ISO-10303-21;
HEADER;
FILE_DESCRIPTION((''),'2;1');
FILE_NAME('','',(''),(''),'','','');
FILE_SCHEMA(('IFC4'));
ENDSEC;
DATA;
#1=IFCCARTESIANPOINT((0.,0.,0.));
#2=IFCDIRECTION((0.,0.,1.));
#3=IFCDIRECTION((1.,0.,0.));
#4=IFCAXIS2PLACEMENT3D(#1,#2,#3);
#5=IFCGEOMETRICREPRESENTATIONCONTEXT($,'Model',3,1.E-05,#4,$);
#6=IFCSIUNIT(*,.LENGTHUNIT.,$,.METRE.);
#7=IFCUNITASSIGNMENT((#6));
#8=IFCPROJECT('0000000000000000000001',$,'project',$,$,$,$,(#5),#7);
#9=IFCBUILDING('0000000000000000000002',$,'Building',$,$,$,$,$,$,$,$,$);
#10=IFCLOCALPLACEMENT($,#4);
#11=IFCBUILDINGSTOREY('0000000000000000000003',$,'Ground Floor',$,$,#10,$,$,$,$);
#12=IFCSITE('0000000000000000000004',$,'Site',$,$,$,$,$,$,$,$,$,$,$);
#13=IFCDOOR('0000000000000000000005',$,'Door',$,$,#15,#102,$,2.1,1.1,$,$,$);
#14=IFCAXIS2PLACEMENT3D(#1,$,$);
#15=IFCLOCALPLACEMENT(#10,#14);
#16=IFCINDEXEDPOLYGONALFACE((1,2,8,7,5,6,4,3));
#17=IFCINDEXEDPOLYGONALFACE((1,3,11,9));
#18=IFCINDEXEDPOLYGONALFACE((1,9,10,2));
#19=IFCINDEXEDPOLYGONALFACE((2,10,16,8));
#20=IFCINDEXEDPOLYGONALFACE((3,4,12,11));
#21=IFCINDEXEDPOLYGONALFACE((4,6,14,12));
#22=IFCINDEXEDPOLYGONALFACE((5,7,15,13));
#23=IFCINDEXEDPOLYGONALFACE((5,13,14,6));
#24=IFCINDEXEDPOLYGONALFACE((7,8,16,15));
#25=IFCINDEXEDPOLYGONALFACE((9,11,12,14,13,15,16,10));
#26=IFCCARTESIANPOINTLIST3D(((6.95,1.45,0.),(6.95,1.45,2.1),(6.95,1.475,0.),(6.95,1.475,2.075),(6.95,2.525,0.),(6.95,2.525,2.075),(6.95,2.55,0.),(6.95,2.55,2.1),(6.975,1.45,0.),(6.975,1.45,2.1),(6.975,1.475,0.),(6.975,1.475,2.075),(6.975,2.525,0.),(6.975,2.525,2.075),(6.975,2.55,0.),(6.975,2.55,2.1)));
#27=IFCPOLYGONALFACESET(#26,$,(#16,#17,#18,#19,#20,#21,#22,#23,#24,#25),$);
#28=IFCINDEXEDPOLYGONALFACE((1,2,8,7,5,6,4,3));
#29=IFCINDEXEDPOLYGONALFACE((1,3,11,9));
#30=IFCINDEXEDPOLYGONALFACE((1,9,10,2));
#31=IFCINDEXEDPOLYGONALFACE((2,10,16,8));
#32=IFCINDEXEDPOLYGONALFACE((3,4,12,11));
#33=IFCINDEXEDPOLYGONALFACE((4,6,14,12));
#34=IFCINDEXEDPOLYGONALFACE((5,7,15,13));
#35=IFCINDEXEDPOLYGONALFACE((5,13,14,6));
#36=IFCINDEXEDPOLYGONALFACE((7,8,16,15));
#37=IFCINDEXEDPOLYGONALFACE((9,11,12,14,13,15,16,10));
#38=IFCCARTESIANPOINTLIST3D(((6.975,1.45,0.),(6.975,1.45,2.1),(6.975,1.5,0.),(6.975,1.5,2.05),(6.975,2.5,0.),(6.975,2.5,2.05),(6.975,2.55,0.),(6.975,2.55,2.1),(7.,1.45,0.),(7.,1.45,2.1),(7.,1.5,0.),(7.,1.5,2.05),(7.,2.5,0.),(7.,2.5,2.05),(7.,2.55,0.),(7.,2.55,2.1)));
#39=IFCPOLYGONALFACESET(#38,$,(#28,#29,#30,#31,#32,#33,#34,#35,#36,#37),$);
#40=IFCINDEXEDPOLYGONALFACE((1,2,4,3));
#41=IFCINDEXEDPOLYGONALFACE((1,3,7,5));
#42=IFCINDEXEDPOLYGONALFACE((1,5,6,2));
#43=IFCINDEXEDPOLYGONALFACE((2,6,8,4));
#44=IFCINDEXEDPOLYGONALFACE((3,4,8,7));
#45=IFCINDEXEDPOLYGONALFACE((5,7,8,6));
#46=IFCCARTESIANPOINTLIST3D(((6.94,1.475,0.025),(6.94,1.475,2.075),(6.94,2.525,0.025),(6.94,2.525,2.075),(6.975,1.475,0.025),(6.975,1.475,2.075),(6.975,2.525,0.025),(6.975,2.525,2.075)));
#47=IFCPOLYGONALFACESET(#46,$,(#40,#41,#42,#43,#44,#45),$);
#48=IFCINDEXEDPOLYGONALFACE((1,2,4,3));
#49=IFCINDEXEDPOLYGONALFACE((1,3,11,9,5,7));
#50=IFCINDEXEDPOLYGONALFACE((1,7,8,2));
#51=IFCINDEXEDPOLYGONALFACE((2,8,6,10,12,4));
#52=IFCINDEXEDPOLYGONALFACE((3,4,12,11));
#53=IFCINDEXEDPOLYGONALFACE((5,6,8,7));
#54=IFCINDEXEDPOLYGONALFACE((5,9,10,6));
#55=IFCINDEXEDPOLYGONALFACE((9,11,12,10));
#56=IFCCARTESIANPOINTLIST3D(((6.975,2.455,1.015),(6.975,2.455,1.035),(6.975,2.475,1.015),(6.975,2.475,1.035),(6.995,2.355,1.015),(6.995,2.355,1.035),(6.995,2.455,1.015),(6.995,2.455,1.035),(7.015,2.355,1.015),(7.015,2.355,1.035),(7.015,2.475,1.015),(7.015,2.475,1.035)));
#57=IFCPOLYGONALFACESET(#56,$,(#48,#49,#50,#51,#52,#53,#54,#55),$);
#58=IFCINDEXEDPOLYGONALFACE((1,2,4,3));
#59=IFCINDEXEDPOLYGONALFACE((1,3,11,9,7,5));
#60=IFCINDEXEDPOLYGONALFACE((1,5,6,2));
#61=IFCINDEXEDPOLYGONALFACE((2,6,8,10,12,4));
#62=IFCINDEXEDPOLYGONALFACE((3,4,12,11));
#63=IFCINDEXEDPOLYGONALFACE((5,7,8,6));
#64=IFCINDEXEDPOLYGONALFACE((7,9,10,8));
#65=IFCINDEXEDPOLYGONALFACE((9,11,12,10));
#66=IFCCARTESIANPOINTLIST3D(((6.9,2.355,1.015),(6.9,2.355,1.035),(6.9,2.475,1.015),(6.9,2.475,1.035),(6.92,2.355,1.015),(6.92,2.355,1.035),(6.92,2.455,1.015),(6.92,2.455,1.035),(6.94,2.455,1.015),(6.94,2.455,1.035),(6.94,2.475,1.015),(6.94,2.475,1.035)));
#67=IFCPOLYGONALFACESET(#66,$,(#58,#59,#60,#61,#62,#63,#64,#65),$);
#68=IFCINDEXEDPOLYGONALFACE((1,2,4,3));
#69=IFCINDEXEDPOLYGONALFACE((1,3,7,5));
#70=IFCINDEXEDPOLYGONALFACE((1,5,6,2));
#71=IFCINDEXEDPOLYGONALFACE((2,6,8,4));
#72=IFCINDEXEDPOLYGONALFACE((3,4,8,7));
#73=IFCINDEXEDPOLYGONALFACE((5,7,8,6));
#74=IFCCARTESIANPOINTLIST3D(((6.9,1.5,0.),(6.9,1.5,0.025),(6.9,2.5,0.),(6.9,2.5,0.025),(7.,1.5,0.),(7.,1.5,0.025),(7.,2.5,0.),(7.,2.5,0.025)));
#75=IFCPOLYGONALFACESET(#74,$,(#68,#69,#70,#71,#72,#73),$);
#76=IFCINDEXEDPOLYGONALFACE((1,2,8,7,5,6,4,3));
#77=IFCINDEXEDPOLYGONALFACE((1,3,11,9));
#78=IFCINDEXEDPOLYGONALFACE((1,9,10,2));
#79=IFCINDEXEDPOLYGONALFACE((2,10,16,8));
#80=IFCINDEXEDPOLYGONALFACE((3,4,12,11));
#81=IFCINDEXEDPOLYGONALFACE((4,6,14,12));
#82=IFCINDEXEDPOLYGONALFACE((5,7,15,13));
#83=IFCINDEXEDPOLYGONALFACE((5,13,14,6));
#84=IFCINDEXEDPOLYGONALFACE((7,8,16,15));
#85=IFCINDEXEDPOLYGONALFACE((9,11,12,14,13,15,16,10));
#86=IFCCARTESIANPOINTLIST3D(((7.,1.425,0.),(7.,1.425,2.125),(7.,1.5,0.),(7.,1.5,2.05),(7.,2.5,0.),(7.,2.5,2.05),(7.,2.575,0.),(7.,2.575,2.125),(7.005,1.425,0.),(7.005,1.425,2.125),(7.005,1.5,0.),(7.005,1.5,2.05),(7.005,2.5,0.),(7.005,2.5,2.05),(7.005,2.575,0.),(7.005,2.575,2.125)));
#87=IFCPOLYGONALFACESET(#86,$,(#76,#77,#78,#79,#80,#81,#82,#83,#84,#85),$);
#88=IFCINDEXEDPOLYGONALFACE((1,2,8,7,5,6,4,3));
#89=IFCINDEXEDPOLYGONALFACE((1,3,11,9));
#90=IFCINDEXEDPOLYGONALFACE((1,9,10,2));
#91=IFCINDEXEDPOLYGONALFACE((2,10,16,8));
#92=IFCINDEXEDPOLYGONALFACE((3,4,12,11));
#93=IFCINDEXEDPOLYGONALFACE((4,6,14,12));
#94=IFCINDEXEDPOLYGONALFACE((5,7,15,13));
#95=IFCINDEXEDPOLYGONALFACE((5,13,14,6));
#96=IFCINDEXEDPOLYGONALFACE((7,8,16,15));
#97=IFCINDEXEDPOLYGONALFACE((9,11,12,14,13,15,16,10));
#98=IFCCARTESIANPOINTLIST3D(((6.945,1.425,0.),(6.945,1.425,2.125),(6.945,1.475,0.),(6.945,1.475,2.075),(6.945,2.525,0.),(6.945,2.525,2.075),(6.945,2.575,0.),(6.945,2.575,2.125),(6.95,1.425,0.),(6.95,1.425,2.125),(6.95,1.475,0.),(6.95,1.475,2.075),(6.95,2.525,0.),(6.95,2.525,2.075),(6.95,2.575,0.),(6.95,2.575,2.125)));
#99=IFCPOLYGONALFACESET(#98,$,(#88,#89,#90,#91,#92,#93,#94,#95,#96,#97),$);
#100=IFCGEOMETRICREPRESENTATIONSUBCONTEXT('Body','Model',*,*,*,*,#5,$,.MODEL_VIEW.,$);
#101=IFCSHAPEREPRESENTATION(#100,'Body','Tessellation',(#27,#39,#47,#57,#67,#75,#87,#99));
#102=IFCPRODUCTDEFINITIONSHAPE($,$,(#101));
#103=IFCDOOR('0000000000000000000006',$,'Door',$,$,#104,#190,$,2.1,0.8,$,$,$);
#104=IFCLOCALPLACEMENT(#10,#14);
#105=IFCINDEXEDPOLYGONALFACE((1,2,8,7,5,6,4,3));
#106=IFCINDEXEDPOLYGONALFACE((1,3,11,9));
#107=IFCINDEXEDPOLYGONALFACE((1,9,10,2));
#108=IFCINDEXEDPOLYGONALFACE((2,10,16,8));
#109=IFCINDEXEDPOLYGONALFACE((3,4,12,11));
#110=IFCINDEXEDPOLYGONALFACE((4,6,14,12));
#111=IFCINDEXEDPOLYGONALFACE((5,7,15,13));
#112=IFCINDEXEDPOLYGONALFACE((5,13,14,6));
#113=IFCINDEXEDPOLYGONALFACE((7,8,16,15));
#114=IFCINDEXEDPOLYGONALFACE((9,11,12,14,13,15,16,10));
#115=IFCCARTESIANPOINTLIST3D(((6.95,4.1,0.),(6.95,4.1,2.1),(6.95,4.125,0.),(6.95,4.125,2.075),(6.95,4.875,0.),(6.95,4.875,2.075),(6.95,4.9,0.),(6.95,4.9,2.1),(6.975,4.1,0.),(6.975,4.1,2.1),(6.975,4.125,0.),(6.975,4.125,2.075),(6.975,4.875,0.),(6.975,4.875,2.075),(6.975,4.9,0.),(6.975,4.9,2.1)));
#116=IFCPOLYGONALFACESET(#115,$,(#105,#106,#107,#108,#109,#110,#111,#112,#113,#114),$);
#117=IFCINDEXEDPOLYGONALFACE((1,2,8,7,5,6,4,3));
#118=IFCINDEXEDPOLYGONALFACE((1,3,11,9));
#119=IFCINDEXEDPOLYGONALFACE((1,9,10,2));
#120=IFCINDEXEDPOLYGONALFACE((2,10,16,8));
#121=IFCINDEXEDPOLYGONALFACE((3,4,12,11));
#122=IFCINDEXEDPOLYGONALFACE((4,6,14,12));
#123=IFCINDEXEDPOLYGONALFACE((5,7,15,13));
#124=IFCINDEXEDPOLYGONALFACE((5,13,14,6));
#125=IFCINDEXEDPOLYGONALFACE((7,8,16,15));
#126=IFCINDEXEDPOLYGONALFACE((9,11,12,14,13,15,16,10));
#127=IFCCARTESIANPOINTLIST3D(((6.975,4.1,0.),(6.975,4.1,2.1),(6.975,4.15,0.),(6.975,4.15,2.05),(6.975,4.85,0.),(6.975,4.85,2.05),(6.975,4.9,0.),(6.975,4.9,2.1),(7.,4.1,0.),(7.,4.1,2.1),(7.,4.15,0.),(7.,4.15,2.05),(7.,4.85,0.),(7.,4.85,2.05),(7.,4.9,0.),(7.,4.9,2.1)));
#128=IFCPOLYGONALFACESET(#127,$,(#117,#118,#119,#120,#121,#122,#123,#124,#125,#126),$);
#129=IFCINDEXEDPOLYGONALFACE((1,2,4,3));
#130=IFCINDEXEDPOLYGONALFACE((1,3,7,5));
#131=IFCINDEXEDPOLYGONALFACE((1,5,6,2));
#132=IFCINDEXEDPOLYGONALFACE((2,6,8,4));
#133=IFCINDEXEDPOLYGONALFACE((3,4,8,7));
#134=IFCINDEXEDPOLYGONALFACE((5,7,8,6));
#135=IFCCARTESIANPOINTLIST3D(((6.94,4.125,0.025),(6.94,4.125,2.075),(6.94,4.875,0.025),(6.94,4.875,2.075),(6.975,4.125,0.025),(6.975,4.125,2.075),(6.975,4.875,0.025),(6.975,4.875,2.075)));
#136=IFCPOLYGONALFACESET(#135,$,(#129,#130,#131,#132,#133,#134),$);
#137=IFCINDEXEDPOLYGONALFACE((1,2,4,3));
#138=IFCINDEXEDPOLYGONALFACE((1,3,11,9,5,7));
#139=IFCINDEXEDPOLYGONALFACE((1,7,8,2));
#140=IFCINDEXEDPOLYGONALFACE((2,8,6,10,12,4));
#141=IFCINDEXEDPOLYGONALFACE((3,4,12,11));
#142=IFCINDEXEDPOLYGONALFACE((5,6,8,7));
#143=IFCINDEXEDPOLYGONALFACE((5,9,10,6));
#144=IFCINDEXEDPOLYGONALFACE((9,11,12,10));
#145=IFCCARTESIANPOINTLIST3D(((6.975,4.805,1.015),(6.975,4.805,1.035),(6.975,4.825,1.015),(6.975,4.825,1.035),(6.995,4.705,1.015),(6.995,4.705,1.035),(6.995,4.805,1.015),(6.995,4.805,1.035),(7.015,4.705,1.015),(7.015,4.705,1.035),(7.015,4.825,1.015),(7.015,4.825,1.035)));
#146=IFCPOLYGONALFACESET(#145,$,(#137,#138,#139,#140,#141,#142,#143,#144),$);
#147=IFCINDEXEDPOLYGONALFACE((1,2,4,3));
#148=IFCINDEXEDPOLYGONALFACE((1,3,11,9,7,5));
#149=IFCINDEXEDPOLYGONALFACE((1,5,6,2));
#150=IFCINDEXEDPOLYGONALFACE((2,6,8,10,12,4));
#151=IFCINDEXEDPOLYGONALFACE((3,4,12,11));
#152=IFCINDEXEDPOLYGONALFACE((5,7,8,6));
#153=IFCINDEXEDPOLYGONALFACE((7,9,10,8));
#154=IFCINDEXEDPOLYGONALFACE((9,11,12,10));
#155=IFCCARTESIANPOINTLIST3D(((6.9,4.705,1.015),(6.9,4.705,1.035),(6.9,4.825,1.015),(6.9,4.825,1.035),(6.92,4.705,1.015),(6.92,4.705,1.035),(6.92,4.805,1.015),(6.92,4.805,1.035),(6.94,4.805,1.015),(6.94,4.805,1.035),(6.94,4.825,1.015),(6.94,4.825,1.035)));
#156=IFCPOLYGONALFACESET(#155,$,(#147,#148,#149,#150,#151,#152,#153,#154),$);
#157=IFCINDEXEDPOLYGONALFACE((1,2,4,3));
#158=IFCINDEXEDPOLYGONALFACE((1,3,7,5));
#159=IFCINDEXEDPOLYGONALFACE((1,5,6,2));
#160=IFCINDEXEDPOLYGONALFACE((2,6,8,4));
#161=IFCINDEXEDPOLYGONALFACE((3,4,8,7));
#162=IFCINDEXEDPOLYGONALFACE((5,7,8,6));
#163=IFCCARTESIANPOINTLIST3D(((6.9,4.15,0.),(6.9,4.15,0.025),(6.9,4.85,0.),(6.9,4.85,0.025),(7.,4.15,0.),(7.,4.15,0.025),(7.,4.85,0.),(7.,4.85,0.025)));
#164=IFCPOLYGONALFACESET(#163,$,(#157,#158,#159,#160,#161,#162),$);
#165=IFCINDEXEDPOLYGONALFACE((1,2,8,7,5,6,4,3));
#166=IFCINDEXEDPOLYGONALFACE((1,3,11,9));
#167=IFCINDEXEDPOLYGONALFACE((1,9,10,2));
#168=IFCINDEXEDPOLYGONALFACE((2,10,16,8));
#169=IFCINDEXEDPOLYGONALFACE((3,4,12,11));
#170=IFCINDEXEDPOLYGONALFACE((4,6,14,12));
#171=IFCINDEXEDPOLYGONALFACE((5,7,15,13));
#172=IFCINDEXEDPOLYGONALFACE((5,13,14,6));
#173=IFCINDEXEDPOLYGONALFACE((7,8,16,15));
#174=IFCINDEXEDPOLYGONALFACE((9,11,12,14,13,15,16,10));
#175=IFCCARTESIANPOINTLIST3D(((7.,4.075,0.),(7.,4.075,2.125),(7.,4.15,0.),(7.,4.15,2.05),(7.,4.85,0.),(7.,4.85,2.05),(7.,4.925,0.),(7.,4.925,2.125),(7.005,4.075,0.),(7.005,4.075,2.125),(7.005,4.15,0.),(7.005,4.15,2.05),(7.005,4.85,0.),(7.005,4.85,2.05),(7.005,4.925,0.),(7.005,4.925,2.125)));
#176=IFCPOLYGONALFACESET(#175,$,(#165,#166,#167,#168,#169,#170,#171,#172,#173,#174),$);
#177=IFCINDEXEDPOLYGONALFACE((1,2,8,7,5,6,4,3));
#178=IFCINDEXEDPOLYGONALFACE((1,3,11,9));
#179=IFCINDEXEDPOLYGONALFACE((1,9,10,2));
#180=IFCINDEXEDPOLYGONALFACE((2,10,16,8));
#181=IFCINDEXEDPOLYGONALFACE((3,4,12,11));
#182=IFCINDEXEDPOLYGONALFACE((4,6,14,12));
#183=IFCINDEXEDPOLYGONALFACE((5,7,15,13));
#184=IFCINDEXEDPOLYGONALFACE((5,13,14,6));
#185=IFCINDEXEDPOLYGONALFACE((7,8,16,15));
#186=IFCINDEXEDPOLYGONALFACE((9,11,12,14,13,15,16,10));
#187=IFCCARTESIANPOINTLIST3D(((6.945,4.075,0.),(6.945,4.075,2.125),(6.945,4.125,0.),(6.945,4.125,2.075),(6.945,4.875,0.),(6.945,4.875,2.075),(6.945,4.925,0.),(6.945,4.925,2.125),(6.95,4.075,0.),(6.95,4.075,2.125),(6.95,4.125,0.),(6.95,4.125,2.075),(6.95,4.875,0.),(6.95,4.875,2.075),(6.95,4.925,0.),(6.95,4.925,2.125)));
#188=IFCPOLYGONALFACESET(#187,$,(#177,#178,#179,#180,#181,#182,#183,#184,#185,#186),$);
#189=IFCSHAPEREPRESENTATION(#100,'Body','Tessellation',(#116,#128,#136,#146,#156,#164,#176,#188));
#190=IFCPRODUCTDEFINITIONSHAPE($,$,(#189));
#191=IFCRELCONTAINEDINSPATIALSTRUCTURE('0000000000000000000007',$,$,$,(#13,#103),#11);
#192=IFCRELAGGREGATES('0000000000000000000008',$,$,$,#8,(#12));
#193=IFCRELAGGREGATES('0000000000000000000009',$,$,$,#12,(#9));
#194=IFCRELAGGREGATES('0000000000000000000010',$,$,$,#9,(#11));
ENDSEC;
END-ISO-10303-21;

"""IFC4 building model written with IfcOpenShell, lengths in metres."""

from ifc_helpers import new_model, si_unit, frame, origin_with_axes, place, context, subcontext, project, spatial, line, indexed_curve, outline, extrude, element, save


model = new_model("IFC4")

# Units and contexts
model_context = context("Model", 3, precision=1e-05, world=origin_with_axes())
body_context = subcontext(model_context, "Body", "Model", "MODEL_VIEW")
ifc_project = project(units=[si_unit("LENGTHUNIT", "METRE")], contexts=[model_context])

# Site, building, storey
site = spatial("IfcSite", under=ifc_project, Name="Site")
building = spatial("IfcBuilding", under=site, Name="Building")
storey_placement = place(None, origin_with_axes())
storey = spatial("IfcBuildingStorey", under=building, at=storey_placement, Name="Ground Floor")

# Doors
door_1_placement = place(storey_placement, frame((7.0, 1.45, 0.0), z_axis=(0.0, 0.0, 1.0), x_axis=(0.0, 1.0, 0.0)))
element("IfcDoor", 1, at=door_1_placement, inside=storey, Name="Door", OverallHeight=2.1, OverallWidth=1.1, context=body_context, shape_type="SweptSolid", body=[
    extrude(outline(indexed_curve([(0.0, 0.0), (0.0, 2.1), (1.1, 2.1), (1.1, 0.0), (1.075, 0.0), (1.075, 2.075), (0.025, 2.075), (0.025, 0.0)], segments=[line(1, 2, 3, 4, 5, 6, 7, 8, 1)])), frame((0.0, 0.025, 0.0), z_axis=(0.0, -1.0, 0.0), x_axis=(1.0, 0.0, 0.0)), (0.0, 0.0, -1.0), 0.025),
    extrude(outline(indexed_curve([(0.0, 0.0), (0.0, 2.1), (1.1, 2.1), (1.1, 0.0), (1.05, 0.0), (1.05, 2.05), (0.05, 2.05), (0.05, 0.0)], segments=[line(1, 2, 3, 4, 5, 6, 7, 8, 1)])), frame((0.0, 0.0, 0.0), z_axis=(0.0, -1.0, 0.0), x_axis=(1.0, 0.0, 0.0)), (0.0, 0.0, -1.0), 0.025),
    extrude(outline(indexed_curve([(0.0, 0.0), (1.05, 0.0), (1.05, 0.035), (0.0, 0.035)], segments=[line(1, 2, 3, 4, 1)])), frame((0.025, 0.025, 0.025), z_axis=(0.0, 0.0, 1.0), x_axis=(1.0, 0.0, 0.0)), (0.0, 0.0, 1.0), 2.05),
    extrude(outline(indexed_curve([(0.0, 0.0), (0.0, -0.04), (-0.12, -0.04), (-0.12, -0.02), (-0.02, -0.02), (-0.02, 0.0)], segments=[line(1, 2, 3, 4, 5, 6, 1)])), frame((1.025, 0.025, 1.015), z_axis=(0.0, 0.0, 1.0), x_axis=(1.0, 0.0, 0.0)), (0.0, 0.0, 1.0), 0.02),
    extrude(outline(indexed_curve([(0.0, 0.0), (0.0, 0.04), (-0.12, 0.04), (-0.12, 0.02), (-0.02, 0.02), (-0.02, 0.0)], segments=[line(1, 2, 3, 4, 5, 6, 1)])), frame((1.025, 0.06, 1.015), z_axis=(0.0, 0.0, 1.0), x_axis=(1.0, 0.0, 0.0)), (0.0, 0.0, 1.0), 0.02),
    extrude(outline(indexed_curve([(0.0, 0.0), (1.0, 0.0), (1.0, 0.1), (0.0, 0.1)], segments=[line(1, 2, 3, 4, 1)])), frame((0.05, 0.0, 0.0), z_axis=(0.0, 0.0, 1.0), x_axis=(1.0, 0.0, 0.0)), (0.0, 0.0, 1.0), 0.025),
    extrude(outline(indexed_curve([(0.0, 0.0), (0.0, 2.125), (1.15, 2.125), (1.15, 0.0), (1.075, 0.0), (1.075, 2.05), (0.075, 2.05), (0.075, 0.0)], segments=[line(1, 2, 3, 4, 5, 6, 7, 8, 1)])), frame((-0.025, -0.005, 0.0), z_axis=(0.0, -1.0, 0.0), x_axis=(1.0, 0.0, 0.0)), (0.0, 0.0, -1.0), 0.005),
    extrude(outline(indexed_curve([(0.0, 0.0), (0.0, 2.125), (1.15, 2.125), (1.15, 0.0), (1.1, 0.0), (1.1, 2.075), (0.05, 2.075), (0.05, 0.0)], segments=[line(1, 2, 3, 4, 5, 6, 7, 8, 1)])), frame((-0.025, 0.05, 0.0), z_axis=(0.0, -1.0, 0.0), x_axis=(1.0, 0.0, 0.0)), (0.0, 0.0, -1.0), 0.005),
])
door_2_placement = place(storey_placement, frame((7.0, 4.1, 0.0), z_axis=(0.0, 0.0, 1.0), x_axis=(0.0, 1.0, 0.0)))
element("IfcDoor", 2, at=door_2_placement, inside=storey, Name="Door", OverallHeight=2.1, OverallWidth=0.8, context=body_context, shape_type="SweptSolid", body=[
    extrude(outline(indexed_curve([(0.0, 0.0), (0.0, 2.1), (0.8, 2.1), (0.8, 0.0), (0.775, 0.0), (0.775, 2.075), (0.025, 2.075), (0.025, 0.0)], segments=[line(1, 2, 3, 4, 5, 6, 7, 8, 1)])), frame((0.0, 0.025, 0.0), z_axis=(0.0, -1.0, 0.0), x_axis=(1.0, 0.0, 0.0)), (0.0, 0.0, -1.0), 0.025),
    extrude(outline(indexed_curve([(0.0, 0.0), (0.0, 2.1), (0.8, 2.1), (0.8, 0.0), (0.75, 0.0), (0.75, 2.05), (0.05, 2.05), (0.05, 0.0)], segments=[line(1, 2, 3, 4, 5, 6, 7, 8, 1)])), frame((0.0, 0.0, 0.0), z_axis=(0.0, -1.0, 0.0), x_axis=(1.0, 0.0, 0.0)), (0.0, 0.0, -1.0), 0.025),
    extrude(outline(indexed_curve([(0.0, 0.0), (0.75, 0.0), (0.75, 0.035), (0.0, 0.035)], segments=[line(1, 2, 3, 4, 1)])), frame((0.025, 0.025, 0.025), z_axis=(0.0, 0.0, 1.0), x_axis=(1.0, 0.0, 0.0)), (0.0, 0.0, 1.0), 2.05),
    extrude(outline(indexed_curve([(0.0, 0.0), (0.0, -0.04), (-0.12, -0.04), (-0.12, -0.02), (-0.02, -0.02), (-0.02, 0.0)], segments=[line(1, 2, 3, 4, 5, 6, 1)])), frame((0.725, 0.025, 1.015), z_axis=(0.0, 0.0, 1.0), x_axis=(1.0, 0.0, 0.0)), (0.0, 0.0, 1.0), 0.02),
    extrude(outline(indexed_curve([(0.0, 0.0), (0.0, 0.04), (-0.12, 0.04), (-0.12, 0.02), (-0.02, 0.02), (-0.02, 0.0)], segments=[line(1, 2, 3, 4, 5, 6, 1)])), frame((0.725, 0.06, 1.015), z_axis=(0.0, 0.0, 1.0), x_axis=(1.0, 0.0, 0.0)), (0.0, 0.0, 1.0), 0.02),
    extrude(outline(indexed_curve([(0.0, 0.0), (0.7, 0.0), (0.7, 0.1), (0.0, 0.1)], segments=[line(1, 2, 3, 4, 1)])), frame((0.05, 0.0, 0.0), z_axis=(0.0, 0.0, 1.0), x_axis=(1.0, 0.0, 0.0)), (0.0, 0.0, 1.0), 0.025),
    extrude(outline(indexed_curve([(0.0, 0.0), (0.0, 2.125), (0.85, 2.125), (0.85, 0.0), (0.775, 0.0), (0.775, 2.05), (0.075, 2.05), (0.075, 0.0)], segments=[line(1, 2, 3, 4, 5, 6, 7, 8, 1)])), frame((-0.025, -0.005, 0.0), z_axis=(0.0, -1.0, 0.0), x_axis=(1.0, 0.0, 0.0)), (0.0, 0.0, -1.0), 0.005),
    extrude(outline(indexed_curve([(0.0, 0.0), (0.0, 2.125), (0.85, 2.125), (0.85, 0.0), (0.8, 0.0), (0.8, 2.075), (0.05, 2.075), (0.05, 0.0)], segments=[line(1, 2, 3, 4, 5, 6, 7, 8, 1)])), frame((-0.025, 0.05, 0.0), z_axis=(0.0, -1.0, 0.0), x_axis=(1.0, 0.0, 0.0)), (0.0, 0.0, -1.0), 0.005),
])

save(model, "model.ifc")
